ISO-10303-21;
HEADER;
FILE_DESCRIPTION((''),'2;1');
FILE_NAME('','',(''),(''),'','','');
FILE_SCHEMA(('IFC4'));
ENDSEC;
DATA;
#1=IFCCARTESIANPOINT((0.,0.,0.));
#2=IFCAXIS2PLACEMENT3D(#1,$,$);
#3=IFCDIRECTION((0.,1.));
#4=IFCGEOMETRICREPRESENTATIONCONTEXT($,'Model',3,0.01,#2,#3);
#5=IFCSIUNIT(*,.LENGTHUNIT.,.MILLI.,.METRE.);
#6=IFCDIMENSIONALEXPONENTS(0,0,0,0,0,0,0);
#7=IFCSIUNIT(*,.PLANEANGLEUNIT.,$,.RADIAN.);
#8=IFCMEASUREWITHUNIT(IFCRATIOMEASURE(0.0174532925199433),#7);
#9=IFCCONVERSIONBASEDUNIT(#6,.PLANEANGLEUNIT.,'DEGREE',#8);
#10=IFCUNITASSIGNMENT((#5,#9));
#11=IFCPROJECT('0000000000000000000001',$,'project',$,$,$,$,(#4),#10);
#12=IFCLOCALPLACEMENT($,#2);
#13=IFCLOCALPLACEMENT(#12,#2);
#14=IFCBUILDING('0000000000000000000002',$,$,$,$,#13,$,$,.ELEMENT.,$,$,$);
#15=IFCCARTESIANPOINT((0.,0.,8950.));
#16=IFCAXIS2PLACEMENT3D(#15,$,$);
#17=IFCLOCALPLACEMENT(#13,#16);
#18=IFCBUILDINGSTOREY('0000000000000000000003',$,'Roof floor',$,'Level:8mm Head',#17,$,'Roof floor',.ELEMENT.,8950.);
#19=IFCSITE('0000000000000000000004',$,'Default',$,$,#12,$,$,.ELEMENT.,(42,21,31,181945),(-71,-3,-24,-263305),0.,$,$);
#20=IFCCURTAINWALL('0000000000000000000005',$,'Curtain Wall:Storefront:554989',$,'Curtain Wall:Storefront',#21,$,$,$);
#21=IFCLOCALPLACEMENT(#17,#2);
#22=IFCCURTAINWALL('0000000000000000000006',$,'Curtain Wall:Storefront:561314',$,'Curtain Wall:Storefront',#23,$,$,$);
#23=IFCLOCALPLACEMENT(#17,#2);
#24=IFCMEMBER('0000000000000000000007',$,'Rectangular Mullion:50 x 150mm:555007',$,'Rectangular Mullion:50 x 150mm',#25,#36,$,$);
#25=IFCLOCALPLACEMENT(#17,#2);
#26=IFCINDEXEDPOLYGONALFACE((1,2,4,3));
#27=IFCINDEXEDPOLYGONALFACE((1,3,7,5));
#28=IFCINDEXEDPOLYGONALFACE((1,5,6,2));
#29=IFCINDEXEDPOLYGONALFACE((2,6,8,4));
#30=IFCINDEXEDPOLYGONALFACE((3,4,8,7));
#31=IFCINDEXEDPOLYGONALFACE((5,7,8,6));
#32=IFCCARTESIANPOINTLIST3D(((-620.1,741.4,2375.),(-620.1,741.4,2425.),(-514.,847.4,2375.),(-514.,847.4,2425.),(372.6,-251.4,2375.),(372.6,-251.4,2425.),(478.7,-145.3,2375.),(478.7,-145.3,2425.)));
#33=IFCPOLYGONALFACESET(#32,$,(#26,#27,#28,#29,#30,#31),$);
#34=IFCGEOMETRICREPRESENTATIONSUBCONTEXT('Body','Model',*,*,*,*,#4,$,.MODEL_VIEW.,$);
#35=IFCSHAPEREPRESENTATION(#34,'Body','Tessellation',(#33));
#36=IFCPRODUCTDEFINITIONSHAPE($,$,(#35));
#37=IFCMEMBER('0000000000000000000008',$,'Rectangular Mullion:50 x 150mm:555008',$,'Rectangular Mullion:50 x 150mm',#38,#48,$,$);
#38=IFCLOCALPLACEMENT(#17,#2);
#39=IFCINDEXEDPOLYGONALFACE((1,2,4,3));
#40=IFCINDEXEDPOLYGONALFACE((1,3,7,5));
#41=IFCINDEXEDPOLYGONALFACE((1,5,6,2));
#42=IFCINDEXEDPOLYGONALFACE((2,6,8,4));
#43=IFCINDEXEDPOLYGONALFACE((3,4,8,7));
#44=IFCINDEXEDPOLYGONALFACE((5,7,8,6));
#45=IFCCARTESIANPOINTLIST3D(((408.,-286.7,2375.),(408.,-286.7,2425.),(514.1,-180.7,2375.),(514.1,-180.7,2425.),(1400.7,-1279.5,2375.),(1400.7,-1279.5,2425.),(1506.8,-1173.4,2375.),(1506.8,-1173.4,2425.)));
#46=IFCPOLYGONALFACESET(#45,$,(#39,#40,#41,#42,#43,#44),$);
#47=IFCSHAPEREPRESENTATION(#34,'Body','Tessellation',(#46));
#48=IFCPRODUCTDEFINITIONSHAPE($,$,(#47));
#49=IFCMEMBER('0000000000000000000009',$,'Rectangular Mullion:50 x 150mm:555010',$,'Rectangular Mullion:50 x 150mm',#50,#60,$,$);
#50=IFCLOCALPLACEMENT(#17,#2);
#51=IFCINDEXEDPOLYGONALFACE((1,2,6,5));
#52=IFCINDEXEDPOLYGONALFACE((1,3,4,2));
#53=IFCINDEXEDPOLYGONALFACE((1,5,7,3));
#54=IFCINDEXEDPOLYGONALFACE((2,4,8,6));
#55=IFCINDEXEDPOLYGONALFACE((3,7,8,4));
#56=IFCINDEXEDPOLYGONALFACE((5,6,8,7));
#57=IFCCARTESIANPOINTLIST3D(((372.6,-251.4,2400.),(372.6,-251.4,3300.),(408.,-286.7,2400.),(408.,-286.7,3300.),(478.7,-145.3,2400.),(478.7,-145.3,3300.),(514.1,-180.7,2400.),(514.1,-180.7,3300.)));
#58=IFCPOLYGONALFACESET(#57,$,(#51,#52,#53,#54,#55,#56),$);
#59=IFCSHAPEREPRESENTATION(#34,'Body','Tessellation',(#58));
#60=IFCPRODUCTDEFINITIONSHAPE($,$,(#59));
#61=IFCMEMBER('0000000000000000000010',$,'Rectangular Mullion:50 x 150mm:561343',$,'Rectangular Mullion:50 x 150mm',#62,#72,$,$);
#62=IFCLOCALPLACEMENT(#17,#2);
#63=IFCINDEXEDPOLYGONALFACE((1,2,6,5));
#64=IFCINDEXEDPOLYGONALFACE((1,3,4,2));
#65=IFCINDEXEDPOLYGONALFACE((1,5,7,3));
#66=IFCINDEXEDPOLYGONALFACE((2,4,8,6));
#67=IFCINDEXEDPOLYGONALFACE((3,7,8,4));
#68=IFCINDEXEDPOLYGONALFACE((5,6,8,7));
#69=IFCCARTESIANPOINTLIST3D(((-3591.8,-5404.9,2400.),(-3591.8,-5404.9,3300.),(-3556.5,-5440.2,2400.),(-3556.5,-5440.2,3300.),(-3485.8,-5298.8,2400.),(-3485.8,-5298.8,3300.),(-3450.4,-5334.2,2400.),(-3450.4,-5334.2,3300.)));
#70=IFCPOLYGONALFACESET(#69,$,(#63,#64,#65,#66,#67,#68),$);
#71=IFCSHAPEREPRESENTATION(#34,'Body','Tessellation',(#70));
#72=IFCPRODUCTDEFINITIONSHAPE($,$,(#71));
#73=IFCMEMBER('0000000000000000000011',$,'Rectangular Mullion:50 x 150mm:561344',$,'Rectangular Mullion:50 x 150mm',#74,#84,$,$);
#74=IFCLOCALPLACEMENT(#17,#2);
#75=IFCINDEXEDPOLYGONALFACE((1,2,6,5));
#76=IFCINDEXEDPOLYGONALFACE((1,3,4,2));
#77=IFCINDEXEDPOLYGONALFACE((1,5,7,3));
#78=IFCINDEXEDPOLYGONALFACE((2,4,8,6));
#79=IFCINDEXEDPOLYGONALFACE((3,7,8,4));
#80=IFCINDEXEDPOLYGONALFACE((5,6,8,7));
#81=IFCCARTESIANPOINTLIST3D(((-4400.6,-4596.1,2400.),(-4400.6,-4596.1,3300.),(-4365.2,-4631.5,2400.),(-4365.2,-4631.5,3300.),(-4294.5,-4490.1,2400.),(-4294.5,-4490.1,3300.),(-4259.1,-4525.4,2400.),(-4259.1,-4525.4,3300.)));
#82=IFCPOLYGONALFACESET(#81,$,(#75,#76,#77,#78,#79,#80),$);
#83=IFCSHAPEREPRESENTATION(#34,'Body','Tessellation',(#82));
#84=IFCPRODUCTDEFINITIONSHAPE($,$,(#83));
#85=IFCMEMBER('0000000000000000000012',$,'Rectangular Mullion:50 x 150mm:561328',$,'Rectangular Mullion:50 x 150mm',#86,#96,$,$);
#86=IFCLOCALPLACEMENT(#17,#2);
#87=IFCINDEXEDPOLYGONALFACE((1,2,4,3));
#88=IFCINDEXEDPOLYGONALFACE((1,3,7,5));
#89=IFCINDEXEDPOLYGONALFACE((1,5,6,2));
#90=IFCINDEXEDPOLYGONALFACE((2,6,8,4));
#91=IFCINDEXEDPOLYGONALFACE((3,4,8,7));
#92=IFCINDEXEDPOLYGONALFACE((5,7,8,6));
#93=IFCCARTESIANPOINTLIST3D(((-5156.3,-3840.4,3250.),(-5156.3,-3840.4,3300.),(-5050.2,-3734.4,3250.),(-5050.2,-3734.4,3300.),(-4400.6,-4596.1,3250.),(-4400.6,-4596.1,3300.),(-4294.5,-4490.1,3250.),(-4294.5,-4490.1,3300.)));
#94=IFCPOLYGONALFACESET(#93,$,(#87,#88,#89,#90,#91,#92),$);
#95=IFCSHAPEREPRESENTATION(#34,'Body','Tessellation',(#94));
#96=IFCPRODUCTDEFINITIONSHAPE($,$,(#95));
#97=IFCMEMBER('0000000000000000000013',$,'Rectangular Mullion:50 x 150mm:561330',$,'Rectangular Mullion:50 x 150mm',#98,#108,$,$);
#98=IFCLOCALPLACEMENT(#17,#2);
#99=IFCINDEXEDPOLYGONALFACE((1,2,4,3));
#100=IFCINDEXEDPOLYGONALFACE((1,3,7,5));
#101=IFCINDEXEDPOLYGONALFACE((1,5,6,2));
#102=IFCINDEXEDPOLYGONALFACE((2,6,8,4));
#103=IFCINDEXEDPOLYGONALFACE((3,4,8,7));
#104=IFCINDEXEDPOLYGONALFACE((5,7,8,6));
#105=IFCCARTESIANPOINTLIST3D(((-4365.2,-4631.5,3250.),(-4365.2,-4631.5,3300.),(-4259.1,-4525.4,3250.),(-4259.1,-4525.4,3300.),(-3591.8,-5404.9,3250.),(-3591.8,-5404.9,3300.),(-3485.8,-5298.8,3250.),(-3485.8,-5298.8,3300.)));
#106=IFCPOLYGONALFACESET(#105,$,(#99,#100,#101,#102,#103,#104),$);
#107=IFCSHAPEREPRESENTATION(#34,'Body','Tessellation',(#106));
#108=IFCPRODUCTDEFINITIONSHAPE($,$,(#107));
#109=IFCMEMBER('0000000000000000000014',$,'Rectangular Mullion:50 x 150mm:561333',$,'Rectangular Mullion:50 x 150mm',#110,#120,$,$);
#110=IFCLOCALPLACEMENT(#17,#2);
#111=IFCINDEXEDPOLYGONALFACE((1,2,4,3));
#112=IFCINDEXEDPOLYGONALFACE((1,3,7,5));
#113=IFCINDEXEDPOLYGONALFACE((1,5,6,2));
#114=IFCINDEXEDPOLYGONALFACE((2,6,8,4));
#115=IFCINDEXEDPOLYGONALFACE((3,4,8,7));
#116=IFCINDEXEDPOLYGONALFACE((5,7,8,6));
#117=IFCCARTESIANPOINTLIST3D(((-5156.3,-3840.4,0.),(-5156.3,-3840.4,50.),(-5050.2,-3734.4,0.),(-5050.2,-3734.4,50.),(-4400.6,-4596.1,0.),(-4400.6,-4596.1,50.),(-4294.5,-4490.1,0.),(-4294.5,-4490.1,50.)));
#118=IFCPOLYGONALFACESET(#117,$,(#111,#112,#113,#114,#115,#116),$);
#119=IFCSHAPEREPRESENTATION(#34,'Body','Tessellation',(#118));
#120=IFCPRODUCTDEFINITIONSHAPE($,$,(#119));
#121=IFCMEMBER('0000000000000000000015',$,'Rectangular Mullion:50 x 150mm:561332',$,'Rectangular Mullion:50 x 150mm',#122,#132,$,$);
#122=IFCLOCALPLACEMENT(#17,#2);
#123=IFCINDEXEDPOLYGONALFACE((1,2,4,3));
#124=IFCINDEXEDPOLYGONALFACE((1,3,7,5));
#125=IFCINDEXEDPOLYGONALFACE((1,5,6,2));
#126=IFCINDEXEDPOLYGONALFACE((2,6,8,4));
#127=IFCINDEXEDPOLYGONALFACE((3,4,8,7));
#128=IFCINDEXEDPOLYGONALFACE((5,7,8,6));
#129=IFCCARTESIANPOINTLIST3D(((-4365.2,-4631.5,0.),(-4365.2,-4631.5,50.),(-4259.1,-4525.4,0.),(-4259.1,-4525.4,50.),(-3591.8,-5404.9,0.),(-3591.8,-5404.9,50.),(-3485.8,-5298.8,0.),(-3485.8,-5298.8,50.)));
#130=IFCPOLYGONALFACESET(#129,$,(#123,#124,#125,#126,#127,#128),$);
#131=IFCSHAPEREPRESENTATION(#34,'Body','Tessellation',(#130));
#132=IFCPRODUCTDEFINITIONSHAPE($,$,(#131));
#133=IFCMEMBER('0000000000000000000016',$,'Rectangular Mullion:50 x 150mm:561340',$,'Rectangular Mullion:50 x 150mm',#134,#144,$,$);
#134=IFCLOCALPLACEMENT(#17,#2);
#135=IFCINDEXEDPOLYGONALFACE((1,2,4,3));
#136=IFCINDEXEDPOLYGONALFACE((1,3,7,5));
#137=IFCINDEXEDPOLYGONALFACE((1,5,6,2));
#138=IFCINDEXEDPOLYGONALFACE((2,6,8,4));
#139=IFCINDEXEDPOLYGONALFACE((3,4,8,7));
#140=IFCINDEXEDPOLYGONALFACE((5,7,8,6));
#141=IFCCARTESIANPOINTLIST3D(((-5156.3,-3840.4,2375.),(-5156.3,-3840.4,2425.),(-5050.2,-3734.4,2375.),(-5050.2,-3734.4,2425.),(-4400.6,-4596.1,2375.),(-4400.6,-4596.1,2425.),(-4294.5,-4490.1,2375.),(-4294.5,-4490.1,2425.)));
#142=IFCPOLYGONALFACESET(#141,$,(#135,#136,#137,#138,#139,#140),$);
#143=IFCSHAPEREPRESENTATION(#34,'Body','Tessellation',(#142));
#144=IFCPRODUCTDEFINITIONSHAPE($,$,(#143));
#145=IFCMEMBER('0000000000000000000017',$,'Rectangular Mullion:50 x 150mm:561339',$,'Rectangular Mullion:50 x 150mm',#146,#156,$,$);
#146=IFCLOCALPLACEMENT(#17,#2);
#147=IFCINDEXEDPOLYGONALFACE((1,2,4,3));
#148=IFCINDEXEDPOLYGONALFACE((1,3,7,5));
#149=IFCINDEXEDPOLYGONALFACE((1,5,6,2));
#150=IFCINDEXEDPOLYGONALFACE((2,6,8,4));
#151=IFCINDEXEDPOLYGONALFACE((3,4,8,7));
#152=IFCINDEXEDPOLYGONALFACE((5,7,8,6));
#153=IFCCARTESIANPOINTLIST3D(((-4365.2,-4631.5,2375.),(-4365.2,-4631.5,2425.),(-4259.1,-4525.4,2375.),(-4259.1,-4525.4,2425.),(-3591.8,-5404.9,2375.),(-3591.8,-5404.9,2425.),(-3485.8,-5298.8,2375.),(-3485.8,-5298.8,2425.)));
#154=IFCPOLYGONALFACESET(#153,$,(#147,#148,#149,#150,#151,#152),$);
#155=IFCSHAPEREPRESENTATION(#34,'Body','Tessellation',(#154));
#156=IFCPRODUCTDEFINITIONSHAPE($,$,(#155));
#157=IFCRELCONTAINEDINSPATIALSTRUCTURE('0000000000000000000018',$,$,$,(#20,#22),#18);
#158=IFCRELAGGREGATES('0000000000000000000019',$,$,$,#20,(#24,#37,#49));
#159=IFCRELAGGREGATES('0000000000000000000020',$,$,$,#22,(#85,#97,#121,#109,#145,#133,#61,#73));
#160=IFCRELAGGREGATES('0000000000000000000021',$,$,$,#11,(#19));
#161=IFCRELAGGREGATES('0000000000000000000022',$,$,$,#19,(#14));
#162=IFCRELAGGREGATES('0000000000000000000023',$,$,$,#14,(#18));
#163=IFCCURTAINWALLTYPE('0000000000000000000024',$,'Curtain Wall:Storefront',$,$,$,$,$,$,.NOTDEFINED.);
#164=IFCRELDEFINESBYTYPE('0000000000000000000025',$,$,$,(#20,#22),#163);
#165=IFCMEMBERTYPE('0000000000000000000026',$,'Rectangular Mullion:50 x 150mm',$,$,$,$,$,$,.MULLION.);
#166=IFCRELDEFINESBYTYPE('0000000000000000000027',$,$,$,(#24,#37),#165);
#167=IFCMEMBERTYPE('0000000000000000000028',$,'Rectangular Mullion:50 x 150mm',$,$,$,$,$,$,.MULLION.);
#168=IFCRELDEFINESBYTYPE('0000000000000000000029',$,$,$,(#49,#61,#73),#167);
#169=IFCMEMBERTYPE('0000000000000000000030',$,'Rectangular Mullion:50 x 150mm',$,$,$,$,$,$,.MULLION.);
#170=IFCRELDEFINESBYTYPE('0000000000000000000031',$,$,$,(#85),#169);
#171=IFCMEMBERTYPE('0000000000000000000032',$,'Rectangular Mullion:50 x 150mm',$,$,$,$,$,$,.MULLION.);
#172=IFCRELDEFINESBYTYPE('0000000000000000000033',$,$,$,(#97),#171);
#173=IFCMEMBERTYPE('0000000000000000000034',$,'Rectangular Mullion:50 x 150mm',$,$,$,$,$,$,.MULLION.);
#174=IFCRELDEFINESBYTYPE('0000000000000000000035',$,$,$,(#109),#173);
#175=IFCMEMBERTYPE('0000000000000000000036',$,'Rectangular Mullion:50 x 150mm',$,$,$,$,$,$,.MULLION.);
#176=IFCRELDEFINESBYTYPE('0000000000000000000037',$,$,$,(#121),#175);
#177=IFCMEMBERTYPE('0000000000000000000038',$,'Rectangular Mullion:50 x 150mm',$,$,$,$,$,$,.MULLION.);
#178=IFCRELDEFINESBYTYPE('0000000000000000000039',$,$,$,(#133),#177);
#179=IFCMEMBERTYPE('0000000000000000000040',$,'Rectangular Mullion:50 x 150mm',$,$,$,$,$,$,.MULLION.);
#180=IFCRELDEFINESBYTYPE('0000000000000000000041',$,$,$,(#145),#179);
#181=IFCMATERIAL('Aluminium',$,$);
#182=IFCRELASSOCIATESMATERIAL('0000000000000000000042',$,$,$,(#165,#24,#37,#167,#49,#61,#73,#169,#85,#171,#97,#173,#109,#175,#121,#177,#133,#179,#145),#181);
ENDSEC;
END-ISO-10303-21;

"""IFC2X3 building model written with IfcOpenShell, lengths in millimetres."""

from ifc_helpers import new_model, entity, si_unit, converted_unit, direction, frame, origin, origin_2d_with_axis, place, context, subcontext, project, spatial, rectangle, extrude, source, transform, mapped, material, type_object, type_shapes, element, aggregate, save


model = new_model("IFC2X3")

# Units and contexts
model_context = context("Model", 3, precision=0.01, world=origin(), true_north=direction((0.0, 1.0)))
body_context = subcontext(model_context, "Body", "Model", "MODEL_VIEW")
ifc_project = project(units=[si_unit("LENGTHUNIT", "METRE", prefix="MILLI"), converted_unit("PLANEANGLEUNIT", "DEGREE", entity("IfcRatioMeasure", 0.0174532925199433), si_unit("PLANEANGLEUNIT", "RADIAN"), dimensions=[0, 0, 0, 0, 0, 0, 0])], contexts=[model_context])

# Site, building, storey
site_placement = place(None, origin())
site = spatial("IfcSite", under=ifc_project, at=site_placement, Name="Default", CompositionType="ELEMENT", RefLatitude=(42, 21, 31, 181945), RefLongitude=(-71, -3, -24, -263305), RefElevation=0.0)
building_placement = place(site_placement, origin())
building = spatial("IfcBuilding", under=site, at=building_placement, CompositionType="ELEMENT")
storey_placement = place(building_placement, frame((0.0, 0.0, 8950.0)))
storey = spatial("IfcBuildingStorey", under=building, at=storey_placement, Name="Roof floor", ObjectType="Level:8mm Head", LongName="Roof floor", CompositionType="ELEMENT", Elevation=8950.0)

# Curtain walls
curtain_wall_type = type_object("IfcCurtainWallType", Name="Curtain Wall:Storefront", PredefinedType="NOTDEFINED")
curtain_wall_1_placement = place(storey_placement, frame((0.0, 0.0, -8950.0)))
curtain_wall_1 = element("IfcCurtainWall", 1, at=curtain_wall_1_placement, inside=storey, type_object=curtain_wall_type, Name="Curtain Wall:Storefront:554989", ObjectType="Curtain Wall:Storefront")
ifc_material_1 = material(Name="Aluminium")
curtain_wall_2_placement = place(storey_placement, frame((0.0, 0.0, -8950.0)))
curtain_wall_2 = element("IfcCurtainWall", 2, at=curtain_wall_2_placement, inside=storey, type_object=curtain_wall_type, Name="Curtain Wall:Storefront:561314", ObjectType="Curtain Wall:Storefront")

# Members
member_type_1 = type_object("IfcMemberType", Name="Rectangular Mullion:50 x 150mm", PredefinedType="MULLION", material=ifc_material_1)
shared_shape_1 = source(origin(), body_context, "Body", "SweptSolid", [
    extrude(rectangle(XDim=150.0, YDim=50.0, at=origin_2d_with_axis()), frame((0.0, 0.0, -1403.9), z_axis=(0.0, 0.0, 1.0), x_axis=(0.0, -1.0, 0.0)), (0.0, 0.0, 1.0), 1403.9),
])
type_shapes(member_type_1, [shared_shape_1])
member_1_placement = place(storey_placement, frame((425.7, -198.3, 2400.0), z_axis=(0.707107, -0.707107, 0.0), x_axis=(0.0, 0.0, 1.0)))
member_1 = element("IfcMember", 3, at=member_1_placement, type_object=member_type_1, material=ifc_material_1, Name="Rectangular Mullion:50 x 150mm:555007", ObjectType="Rectangular Mullion:50 x 150mm", context=body_context, shape_type="MappedRepresentation", body=[
    mapped(shared_shape_1, transform((0.0, 0.0, 0.0), scale=1.0)),
])
member_2_placement = place(storey_placement, frame((1453.8, -1226.4, 2400.0), z_axis=(0.707107, -0.707107, 0.0), x_axis=(0.0, 0.0, 1.0)))
member_2 = element("IfcMember", 4, at=member_2_placement, type_object=member_type_1, material=ifc_material_1, Name="Rectangular Mullion:50 x 150mm:555008", ObjectType="Rectangular Mullion:50 x 150mm", context=body_context, shape_type="MappedRepresentation", body=[
    mapped(shared_shape_1, transform((0.0, 0.0, 0.0), scale=1.0)),
])
member_type_2 = type_object("IfcMemberType", Name="Rectangular Mullion:50 x 150mm", PredefinedType="MULLION", material=ifc_material_1)
shared_shape_2 = source(origin(), body_context, "Body", "SweptSolid", [
    extrude(rectangle(XDim=150.0, YDim=50.0, at=origin_2d_with_axis()), frame((0.0, 0.0, -900.0), z_axis=(0.0, 0.0, 1.0), x_axis=(0.0, -1.0, 0.0)), (0.0, 0.0, 1.0), 900.0),
])
type_shapes(member_type_2, [shared_shape_2])
member_3_placement = place(storey_placement, frame((443.4, -216.0, 2400.0), z_axis=(0.0, 0.0, -1.0), x_axis=(0.707107, -0.707107, 0.0)))
member_3 = element("IfcMember", 5, at=member_3_placement, type_object=member_type_2, material=ifc_material_1, Name="Rectangular Mullion:50 x 150mm:555010", ObjectType="Rectangular Mullion:50 x 150mm", context=body_context, shape_type="MappedRepresentation", body=[
    mapped(shared_shape_2, transform((0.0, 0.0, 0.0), scale=1.0)),
])
member_4_placement = place(storey_placement, frame((-3521.1, -5369.5, 2400.0), z_axis=(0.0, 0.0, -1.0), x_axis=(-0.707107, 0.707107, 0.0)))
member_4 = element("IfcMember", 6, at=member_4_placement, type_object=member_type_2, material=ifc_material_1, Name="Rectangular Mullion:50 x 150mm:561343", ObjectType="Rectangular Mullion:50 x 150mm", context=body_context, shape_type="MappedRepresentation", body=[
    mapped(shared_shape_2, transform((0.0, 0.0, 0.0), scale=1.0)),
])
member_5_placement = place(storey_placement, frame((-4329.9, -4560.8, 2400.0), z_axis=(0.0, 0.0, -1.0), x_axis=(-0.707107, 0.707107, 0.0)))
member_5 = element("IfcMember", 7, at=member_5_placement, type_object=member_type_2, material=ifc_material_1, Name="Rectangular Mullion:50 x 150mm:561344", ObjectType="Rectangular Mullion:50 x 150mm", context=body_context, shape_type="MappedRepresentation", body=[
    mapped(shared_shape_2, transform((0.0, 0.0, 0.0), scale=1.0)),
])
member_type_3 = type_object("IfcMemberType", Name="Rectangular Mullion:50 x 150mm", PredefinedType="MULLION", material=ifc_material_1)
shared_shape_3 = source(origin(), body_context, "Body", "SweptSolid", [
    extrude(rectangle(XDim=150.0, YDim=50.0, at=origin_2d_with_axis()), frame((-25.0, 0.0, -1068.7), z_axis=(0.0, 0.0, 1.0), x_axis=(0.0, -1.0, 0.0)), (0.0, 0.0, 1.0), 1068.7),
])
type_shapes(member_type_3, [shared_shape_3])
member_6_placement = place(storey_placement, frame((-5103.2, -3787.4, 3300.0), z_axis=(-0.707107, 0.707107, 0.0), x_axis=(0.0, 0.0, 1.0)))
member_6 = element("IfcMember", 8, at=member_6_placement, type_object=member_type_3, material=ifc_material_1, Name="Rectangular Mullion:50 x 150mm:561328", ObjectType="Rectangular Mullion:50 x 150mm", context=body_context, shape_type="MappedRepresentation", body=[
    mapped(shared_shape_3, transform((0.0, 0.0, 0.0), scale=1.0)),
])
member_type_4 = type_object("IfcMemberType", Name="Rectangular Mullion:50 x 150mm", PredefinedType="MULLION", material=ifc_material_1)
shared_shape_4 = source(origin(), body_context, "Body", "SweptSolid", [
    extrude(rectangle(XDim=150.0, YDim=50.0, at=origin_2d_with_axis()), frame((-25.0, 0.0, -1093.7), z_axis=(0.0, 0.0, 1.0), x_axis=(0.0, -1.0, 0.0)), (0.0, 0.0, 1.0), 1093.7),
])
type_shapes(member_type_4, [shared_shape_4])
member_7_placement = place(storey_placement, frame((-4312.2, -4578.5, 3300.0), z_axis=(-0.707107, 0.707107, 0.0), x_axis=(0.0, 0.0, 1.0)))
member_7 = element("IfcMember", 9, at=member_7_placement, type_object=member_type_4, material=ifc_material_1, Name="Rectangular Mullion:50 x 150mm:561330", ObjectType="Rectangular Mullion:50 x 150mm", context=body_context, shape_type="MappedRepresentation", body=[
    mapped(shared_shape_4, transform((0.0, 0.0, 0.0), scale=1.0)),
])
member_type_5 = type_object("IfcMemberType", Name="Rectangular Mullion:50 x 150mm", PredefinedType="MULLION", material=ifc_material_1)
shared_shape_5 = source(origin(), body_context, "Body", "SweptSolid", [
    extrude(rectangle(XDim=150.0, YDim=50.0, at=origin_2d_with_axis()), frame((-25.0, 0.0, -1068.7), z_axis=(0.0, 0.0, 1.0), x_axis=(0.0, -1.0, 0.0)), (0.0, 0.0, 1.0), 1068.7),
])
type_shapes(member_type_5, [shared_shape_5])
member_8_placement = place(storey_placement, frame((-4347.5, -4543.1, 0.0), z_axis=(0.707107, -0.707107, 0.0), x_axis=(0.0, 0.0, -1.0)))
member_8 = element("IfcMember", 10, at=member_8_placement, type_object=member_type_5, material=ifc_material_1, Name="Rectangular Mullion:50 x 150mm:561333", ObjectType="Rectangular Mullion:50 x 150mm", context=body_context, shape_type="MappedRepresentation", body=[
    mapped(shared_shape_5, transform((0.0, 0.0, 0.0), scale=1.0)),
])
member_type_6 = type_object("IfcMemberType", Name="Rectangular Mullion:50 x 150mm", PredefinedType="MULLION", material=ifc_material_1)
shared_shape_6 = source(origin(), body_context, "Body", "SweptSolid", [
    extrude(rectangle(XDim=150.0, YDim=50.0, at=origin_2d_with_axis()), frame((-25.0, 0.0, -1093.7), z_axis=(0.0, 0.0, 1.0), x_axis=(0.0, -1.0, 0.0)), (0.0, 0.0, 1.0), 1093.7),
])
type_shapes(member_type_6, [shared_shape_6])
member_9_placement = place(storey_placement, frame((-3538.8, -5351.9, 0.0), z_axis=(0.707107, -0.707107, 0.0), x_axis=(0.0, 0.0, -1.0)))
member_9 = element("IfcMember", 11, at=member_9_placement, type_object=member_type_6, material=ifc_material_1, Name="Rectangular Mullion:50 x 150mm:561332", ObjectType="Rectangular Mullion:50 x 150mm", context=body_context, shape_type="MappedRepresentation", body=[
    mapped(shared_shape_6, transform((0.0, 0.0, 0.0), scale=1.0)),
])
member_type_7 = type_object("IfcMemberType", Name="Rectangular Mullion:50 x 150mm", PredefinedType="MULLION", material=ifc_material_1)
shared_shape_7 = source(origin(), body_context, "Body", "SweptSolid", [
    extrude(rectangle(XDim=150.0, YDim=50.0, at=origin_2d_with_axis()), frame((0.0, 0.0, -1068.7), z_axis=(0.0, 0.0, 1.0), x_axis=(0.0, -1.0, 0.0)), (0.0, 0.0, 1.0), 1068.7),
])
type_shapes(member_type_7, [shared_shape_7])
member_10_placement = place(storey_placement, frame((-5103.2, -3787.4, 2400.0), z_axis=(-0.707107, 0.707107, 0.0), x_axis=(0.0, 0.0, 1.0)))
member_10 = element("IfcMember", 12, at=member_10_placement, type_object=member_type_7, material=ifc_material_1, Name="Rectangular Mullion:50 x 150mm:561340", ObjectType="Rectangular Mullion:50 x 150mm", context=body_context, shape_type="MappedRepresentation", body=[
    mapped(shared_shape_7, transform((0.0, 0.0, 0.0), scale=1.0)),
])
member_type_8 = type_object("IfcMemberType", Name="Rectangular Mullion:50 x 150mm", PredefinedType="MULLION", material=ifc_material_1)
shared_shape_8 = source(origin(), body_context, "Body", "SweptSolid", [
    extrude(rectangle(XDim=150.0, YDim=50.0, at=origin_2d_with_axis()), frame((0.0, 0.0, -1093.7), z_axis=(0.0, 0.0, 1.0), x_axis=(0.0, -1.0, 0.0)), (0.0, 0.0, 1.0), 1093.7),
])
type_shapes(member_type_8, [shared_shape_8])
member_11_placement = place(storey_placement, frame((-4312.2, -4578.5, 2400.0), z_axis=(-0.707107, 0.707107, 0.0), x_axis=(0.0, 0.0, 1.0)))
member_11 = element("IfcMember", 13, at=member_11_placement, type_object=member_type_8, material=ifc_material_1, Name="Rectangular Mullion:50 x 150mm:561339", ObjectType="Rectangular Mullion:50 x 150mm", context=body_context, shape_type="MappedRepresentation", body=[
    mapped(shared_shape_8, transform((0.0, 0.0, 0.0), scale=1.0)),
])

aggregate(curtain_wall_1, [member_1, member_2, member_3])
aggregate(curtain_wall_2, [member_6, member_7, member_9, member_8, member_11, member_10, member_4, member_5])

save(model, "model.ifc")
